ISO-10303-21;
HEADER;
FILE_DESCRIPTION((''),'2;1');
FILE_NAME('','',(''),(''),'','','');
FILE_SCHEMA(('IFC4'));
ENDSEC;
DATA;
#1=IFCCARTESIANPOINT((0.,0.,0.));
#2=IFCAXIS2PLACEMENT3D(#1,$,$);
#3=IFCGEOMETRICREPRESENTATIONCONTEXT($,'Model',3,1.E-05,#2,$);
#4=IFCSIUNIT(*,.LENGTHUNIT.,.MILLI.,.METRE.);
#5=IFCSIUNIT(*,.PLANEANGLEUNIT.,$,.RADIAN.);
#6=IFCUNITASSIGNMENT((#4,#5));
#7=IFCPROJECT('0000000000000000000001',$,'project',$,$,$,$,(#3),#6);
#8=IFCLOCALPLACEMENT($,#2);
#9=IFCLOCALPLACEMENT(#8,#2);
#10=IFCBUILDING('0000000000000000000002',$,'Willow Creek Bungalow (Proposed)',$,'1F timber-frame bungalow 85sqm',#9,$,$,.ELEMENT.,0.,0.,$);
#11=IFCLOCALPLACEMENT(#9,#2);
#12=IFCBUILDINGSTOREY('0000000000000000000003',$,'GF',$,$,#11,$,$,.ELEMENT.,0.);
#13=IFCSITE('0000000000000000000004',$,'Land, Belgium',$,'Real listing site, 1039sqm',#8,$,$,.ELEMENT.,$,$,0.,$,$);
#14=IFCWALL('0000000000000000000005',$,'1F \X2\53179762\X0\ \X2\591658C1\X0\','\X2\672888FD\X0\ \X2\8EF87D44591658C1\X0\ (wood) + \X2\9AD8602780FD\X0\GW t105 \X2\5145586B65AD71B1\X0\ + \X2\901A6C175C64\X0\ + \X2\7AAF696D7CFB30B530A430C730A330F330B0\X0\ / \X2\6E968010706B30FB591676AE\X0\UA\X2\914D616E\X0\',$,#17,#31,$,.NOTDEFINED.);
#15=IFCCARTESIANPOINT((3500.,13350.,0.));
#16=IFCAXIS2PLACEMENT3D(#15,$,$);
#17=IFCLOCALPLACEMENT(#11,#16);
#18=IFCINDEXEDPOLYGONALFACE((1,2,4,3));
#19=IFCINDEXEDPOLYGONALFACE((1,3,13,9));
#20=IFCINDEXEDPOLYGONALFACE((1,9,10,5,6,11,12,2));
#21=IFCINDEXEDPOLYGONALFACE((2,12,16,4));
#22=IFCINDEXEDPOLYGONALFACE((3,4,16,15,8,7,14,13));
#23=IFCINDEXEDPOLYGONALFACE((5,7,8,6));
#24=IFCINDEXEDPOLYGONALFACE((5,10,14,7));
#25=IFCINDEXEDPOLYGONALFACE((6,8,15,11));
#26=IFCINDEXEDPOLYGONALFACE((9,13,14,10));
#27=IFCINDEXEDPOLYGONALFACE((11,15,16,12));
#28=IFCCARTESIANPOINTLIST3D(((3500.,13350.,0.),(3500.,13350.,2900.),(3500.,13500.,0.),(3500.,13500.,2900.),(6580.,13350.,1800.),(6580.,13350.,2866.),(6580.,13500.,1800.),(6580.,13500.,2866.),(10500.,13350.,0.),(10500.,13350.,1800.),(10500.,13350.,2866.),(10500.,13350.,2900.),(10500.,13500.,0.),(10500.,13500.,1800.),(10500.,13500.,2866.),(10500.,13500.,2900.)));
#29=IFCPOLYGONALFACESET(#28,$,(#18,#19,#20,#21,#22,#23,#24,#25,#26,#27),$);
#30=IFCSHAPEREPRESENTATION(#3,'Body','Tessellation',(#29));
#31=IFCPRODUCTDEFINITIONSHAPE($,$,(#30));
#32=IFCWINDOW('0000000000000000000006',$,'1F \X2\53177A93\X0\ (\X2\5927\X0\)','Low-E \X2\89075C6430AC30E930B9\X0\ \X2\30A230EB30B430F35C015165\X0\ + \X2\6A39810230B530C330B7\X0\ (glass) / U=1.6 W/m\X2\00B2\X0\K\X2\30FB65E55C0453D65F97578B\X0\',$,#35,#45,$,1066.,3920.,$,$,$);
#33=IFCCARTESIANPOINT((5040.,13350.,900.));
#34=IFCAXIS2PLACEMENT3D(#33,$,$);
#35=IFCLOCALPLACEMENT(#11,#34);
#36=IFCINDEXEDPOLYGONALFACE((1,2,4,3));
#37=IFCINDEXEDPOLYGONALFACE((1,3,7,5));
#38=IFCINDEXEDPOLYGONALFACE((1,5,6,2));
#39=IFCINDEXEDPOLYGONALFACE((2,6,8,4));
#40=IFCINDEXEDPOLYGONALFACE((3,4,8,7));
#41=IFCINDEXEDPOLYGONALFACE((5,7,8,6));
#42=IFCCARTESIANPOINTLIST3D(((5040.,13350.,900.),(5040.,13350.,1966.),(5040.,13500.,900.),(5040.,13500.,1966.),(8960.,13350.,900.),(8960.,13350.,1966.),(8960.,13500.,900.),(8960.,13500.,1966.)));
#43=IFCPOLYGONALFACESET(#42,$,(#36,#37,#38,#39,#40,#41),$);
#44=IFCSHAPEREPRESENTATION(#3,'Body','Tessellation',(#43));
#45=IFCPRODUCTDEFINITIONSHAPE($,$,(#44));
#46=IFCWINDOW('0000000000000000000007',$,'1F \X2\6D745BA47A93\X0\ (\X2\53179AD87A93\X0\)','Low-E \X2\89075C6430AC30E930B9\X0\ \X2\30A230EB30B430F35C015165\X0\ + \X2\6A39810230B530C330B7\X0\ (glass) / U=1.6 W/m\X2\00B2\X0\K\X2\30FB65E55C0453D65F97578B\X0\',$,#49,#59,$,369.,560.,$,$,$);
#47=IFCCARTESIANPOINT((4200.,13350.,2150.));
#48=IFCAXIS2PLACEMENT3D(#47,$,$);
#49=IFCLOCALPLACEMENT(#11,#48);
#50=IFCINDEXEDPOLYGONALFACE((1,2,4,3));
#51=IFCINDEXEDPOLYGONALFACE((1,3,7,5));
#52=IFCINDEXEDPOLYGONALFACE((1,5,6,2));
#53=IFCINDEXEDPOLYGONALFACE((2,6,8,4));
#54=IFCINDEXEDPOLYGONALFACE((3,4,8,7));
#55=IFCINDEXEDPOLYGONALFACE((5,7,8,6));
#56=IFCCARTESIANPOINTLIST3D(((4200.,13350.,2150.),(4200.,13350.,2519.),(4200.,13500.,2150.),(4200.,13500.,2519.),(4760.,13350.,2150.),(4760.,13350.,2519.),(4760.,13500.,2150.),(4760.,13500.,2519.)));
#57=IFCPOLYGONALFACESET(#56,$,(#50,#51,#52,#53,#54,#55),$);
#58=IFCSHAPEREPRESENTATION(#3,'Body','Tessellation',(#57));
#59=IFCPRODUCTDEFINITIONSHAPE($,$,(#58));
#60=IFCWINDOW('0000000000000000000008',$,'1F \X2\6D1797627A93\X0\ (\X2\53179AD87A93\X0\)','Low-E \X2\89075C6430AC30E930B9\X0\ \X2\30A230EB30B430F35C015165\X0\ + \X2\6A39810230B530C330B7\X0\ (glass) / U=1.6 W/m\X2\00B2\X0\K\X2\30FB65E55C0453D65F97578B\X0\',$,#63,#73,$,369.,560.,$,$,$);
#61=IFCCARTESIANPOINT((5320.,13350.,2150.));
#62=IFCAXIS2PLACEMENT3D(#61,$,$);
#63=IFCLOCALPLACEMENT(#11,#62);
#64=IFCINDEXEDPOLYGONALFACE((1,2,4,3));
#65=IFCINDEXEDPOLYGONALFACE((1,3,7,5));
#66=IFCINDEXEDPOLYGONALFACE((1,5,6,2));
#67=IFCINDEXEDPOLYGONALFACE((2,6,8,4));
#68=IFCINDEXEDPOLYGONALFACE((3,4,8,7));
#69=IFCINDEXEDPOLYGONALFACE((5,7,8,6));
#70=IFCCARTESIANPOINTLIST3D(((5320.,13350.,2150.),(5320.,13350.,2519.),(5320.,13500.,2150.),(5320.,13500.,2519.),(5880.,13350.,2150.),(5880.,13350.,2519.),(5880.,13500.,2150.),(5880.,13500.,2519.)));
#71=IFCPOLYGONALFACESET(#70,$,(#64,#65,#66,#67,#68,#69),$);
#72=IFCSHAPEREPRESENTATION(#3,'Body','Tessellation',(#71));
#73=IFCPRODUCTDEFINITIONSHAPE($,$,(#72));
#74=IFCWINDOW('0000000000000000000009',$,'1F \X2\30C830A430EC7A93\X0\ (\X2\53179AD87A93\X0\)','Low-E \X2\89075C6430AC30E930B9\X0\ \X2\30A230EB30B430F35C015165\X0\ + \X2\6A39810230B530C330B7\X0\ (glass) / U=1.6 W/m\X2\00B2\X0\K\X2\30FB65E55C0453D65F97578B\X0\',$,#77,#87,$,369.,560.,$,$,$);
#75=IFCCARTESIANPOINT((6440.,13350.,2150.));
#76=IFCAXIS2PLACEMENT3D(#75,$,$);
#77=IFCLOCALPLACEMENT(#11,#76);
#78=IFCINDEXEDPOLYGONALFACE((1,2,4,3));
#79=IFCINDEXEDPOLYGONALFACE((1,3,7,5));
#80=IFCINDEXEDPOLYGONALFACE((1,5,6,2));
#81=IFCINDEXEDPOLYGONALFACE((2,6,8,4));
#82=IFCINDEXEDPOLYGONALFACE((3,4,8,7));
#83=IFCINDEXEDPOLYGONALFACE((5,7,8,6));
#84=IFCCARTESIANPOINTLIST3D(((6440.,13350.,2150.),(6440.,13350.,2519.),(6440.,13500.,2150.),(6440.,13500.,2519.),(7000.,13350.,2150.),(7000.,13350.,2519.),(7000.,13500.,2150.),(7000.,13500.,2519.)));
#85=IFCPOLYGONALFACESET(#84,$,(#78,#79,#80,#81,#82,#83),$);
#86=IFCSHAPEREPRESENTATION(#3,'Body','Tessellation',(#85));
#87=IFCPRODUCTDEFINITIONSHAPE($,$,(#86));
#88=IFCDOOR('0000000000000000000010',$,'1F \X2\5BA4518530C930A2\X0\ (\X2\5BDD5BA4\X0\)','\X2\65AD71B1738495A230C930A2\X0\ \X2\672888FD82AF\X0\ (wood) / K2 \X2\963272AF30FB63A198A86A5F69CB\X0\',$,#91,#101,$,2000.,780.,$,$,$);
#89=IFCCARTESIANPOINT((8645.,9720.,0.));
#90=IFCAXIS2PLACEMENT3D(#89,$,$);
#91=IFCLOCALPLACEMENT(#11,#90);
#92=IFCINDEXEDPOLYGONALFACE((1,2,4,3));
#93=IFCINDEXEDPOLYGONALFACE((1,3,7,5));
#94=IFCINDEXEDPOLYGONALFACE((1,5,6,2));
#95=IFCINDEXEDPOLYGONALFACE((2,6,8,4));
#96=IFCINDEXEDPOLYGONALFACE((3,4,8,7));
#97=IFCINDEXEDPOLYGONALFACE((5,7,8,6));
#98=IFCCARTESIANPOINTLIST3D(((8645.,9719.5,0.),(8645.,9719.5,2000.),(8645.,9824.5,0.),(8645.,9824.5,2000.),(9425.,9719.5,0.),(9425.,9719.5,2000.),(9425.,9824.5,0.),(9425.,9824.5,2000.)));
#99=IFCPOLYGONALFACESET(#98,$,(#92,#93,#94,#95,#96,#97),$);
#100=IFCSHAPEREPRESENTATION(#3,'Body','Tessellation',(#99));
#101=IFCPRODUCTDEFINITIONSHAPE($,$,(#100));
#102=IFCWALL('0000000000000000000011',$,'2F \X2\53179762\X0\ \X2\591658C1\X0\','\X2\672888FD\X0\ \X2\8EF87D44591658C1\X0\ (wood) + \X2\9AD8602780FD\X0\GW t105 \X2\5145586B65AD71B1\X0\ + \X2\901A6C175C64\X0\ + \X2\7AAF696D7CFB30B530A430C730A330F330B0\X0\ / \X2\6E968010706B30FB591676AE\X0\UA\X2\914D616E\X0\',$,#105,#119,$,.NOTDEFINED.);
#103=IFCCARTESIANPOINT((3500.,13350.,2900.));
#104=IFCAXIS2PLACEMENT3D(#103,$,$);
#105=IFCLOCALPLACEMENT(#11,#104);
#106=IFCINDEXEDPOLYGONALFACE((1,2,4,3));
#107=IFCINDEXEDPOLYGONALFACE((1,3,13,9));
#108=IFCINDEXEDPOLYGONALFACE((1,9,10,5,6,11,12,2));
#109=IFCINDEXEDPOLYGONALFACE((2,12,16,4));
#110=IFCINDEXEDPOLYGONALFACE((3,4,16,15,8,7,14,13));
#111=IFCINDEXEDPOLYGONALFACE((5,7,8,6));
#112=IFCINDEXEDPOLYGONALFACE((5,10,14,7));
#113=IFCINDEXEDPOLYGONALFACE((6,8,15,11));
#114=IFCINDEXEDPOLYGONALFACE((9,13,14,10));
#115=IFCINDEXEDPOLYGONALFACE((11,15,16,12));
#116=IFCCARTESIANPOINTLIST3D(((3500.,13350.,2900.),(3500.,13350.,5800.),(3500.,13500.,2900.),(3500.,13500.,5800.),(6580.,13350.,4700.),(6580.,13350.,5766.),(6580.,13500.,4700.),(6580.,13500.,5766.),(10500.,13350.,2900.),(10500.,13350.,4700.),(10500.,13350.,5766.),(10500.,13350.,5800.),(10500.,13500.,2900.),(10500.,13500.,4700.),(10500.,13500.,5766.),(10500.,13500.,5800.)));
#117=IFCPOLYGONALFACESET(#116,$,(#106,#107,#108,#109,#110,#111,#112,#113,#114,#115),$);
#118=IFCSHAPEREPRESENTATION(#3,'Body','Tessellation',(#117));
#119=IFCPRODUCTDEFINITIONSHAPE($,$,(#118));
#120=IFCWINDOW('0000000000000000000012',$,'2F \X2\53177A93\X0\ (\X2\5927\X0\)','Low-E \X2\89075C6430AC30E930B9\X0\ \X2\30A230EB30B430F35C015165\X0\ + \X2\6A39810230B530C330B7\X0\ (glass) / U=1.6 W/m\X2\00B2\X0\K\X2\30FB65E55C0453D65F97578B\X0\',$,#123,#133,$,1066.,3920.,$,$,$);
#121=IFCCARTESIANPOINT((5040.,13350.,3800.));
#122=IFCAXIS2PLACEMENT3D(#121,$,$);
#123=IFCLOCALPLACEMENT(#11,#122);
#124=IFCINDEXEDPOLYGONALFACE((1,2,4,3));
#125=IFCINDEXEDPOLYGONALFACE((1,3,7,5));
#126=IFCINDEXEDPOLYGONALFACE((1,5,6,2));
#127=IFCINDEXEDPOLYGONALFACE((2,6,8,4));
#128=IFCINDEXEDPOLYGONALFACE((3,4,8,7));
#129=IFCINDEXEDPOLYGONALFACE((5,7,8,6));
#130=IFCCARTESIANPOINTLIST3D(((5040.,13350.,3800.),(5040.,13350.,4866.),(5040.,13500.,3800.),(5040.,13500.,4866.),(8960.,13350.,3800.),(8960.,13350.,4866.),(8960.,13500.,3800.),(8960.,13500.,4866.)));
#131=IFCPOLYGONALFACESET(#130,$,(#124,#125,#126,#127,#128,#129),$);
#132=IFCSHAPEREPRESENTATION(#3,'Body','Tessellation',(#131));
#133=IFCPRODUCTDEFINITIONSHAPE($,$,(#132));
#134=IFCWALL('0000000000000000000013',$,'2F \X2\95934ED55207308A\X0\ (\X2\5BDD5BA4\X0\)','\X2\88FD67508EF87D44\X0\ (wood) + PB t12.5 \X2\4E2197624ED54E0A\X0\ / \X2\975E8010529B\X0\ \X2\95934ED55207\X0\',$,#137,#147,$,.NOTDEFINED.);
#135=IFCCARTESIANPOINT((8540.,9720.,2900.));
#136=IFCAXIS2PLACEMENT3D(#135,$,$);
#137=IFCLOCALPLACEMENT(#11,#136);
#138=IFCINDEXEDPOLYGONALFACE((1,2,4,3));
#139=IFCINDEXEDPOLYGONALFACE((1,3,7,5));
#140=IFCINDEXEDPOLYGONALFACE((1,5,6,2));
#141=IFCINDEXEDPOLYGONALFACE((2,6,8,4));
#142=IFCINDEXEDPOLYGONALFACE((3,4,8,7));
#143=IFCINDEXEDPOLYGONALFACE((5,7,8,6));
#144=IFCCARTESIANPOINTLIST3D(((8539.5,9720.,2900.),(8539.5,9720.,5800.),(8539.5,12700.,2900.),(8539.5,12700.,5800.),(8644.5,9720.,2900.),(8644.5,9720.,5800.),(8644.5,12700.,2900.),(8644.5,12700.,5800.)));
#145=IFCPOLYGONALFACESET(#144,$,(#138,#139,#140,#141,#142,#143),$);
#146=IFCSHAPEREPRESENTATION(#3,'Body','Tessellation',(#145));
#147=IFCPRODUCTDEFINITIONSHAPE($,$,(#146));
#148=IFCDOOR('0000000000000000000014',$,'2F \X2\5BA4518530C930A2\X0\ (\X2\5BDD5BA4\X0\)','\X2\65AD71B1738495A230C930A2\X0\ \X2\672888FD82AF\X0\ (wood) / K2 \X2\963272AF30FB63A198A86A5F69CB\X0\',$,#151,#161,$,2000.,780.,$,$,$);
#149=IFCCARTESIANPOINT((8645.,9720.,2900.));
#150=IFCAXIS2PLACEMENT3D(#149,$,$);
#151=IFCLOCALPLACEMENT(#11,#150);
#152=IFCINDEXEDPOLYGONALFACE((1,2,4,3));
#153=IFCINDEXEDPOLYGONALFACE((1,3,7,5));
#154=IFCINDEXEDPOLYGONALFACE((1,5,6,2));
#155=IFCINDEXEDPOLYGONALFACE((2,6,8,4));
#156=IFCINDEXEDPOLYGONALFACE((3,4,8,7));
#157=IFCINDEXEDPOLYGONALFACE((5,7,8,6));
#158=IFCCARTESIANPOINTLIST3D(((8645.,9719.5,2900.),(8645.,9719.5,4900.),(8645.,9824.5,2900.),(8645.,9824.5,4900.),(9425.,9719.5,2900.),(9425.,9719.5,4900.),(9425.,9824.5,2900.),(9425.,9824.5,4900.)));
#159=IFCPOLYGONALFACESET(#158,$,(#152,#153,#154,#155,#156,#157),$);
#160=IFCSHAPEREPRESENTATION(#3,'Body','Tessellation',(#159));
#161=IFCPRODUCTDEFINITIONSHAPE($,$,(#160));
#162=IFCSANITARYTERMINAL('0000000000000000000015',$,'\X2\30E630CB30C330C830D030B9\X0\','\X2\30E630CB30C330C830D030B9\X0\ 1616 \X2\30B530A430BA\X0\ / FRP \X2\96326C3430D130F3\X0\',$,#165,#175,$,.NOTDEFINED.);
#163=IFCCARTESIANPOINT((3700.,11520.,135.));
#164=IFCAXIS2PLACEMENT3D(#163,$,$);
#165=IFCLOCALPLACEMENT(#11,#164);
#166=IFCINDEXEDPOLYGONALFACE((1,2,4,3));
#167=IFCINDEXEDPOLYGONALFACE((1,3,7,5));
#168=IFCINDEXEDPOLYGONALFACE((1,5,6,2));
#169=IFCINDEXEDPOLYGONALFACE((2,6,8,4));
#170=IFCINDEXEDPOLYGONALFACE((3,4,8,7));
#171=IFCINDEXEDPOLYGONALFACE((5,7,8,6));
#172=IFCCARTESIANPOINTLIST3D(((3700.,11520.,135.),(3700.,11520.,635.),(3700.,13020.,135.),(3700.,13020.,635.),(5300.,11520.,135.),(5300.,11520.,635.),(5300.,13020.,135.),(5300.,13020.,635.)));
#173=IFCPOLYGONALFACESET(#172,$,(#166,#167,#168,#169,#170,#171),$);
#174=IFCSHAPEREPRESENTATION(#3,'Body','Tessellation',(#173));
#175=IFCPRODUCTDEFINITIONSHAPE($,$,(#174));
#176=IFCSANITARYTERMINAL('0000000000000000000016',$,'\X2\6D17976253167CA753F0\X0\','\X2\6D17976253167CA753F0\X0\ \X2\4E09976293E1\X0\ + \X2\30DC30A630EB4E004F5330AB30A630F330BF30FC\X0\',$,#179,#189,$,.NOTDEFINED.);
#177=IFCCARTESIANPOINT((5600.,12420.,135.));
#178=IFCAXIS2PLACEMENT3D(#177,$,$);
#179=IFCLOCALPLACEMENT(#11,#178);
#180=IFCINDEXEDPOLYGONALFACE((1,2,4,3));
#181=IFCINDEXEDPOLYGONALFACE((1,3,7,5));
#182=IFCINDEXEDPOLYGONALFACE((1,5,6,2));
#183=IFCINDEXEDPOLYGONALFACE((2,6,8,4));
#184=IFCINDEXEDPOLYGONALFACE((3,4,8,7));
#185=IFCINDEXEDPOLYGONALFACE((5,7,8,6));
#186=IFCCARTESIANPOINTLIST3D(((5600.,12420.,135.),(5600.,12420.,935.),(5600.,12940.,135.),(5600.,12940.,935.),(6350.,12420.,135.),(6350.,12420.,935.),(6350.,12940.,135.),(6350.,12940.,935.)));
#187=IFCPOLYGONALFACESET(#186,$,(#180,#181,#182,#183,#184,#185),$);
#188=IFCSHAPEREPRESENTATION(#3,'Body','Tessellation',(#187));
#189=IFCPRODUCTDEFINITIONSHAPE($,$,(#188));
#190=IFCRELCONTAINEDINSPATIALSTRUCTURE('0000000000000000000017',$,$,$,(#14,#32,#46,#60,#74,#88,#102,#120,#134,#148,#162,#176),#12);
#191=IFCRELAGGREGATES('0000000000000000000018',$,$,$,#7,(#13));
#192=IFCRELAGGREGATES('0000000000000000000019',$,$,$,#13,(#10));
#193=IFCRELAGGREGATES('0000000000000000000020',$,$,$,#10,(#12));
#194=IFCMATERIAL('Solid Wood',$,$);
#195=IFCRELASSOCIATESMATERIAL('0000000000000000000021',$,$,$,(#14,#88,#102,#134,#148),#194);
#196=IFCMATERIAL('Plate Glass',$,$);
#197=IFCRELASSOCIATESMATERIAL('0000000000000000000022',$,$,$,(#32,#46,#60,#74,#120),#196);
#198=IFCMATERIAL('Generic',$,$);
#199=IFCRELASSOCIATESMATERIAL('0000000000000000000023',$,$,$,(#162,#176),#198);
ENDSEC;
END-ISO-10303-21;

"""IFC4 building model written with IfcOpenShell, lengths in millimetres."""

from ifc_helpers import new_model, si_unit, frame, frame_2d, origin, place, context, project, spatial, rectangle, extrude, material, element, fill, save


model = new_model("IFC4")

# Units and contexts
model_context = context("Model", 3, precision=1e-05, world=origin())
ifc_project = project(units=[si_unit("LENGTHUNIT", "METRE", prefix="MILLI"), si_unit("PLANEANGLEUNIT", "RADIAN")], contexts=[model_context])

# Site, building, storey
site_placement = place(None, origin())
site = spatial("IfcSite", under=ifc_project, at=site_placement, Name="Land, Belgium", ObjectType="Real listing site, 1039sqm", CompositionType="ELEMENT", RefElevation=0.0)
building_placement = place(site_placement, origin())
building = spatial("IfcBuilding", under=site, at=building_placement, Name="Willow Creek Bungalow (Proposed)", ObjectType="1F timber-frame bungalow 85sqm", CompositionType="ELEMENT", ElevationOfRefHeight=0.0, ElevationOfTerrain=0.0)
storey_placement = place(building_placement, origin())
storey = spatial("IfcBuildingStorey", under=building, at=storey_placement, Name="GF", CompositionType="ELEMENT", Elevation=0.0)

# Wall, openings, windows
ifc_material_1 = material(Name="Solid Wood")
wall_1_placement = place(storey_placement, frame((3500.0, 13350.0, 0.0)))
wall_1 = element("IfcWall", 1, at=wall_1_placement, inside=storey, material=ifc_material_1, Name="1F 北面 外壁", Description="木製 軸組外壁 (wood) + 高性能GW t105 充填断熱 + 通気層 + 窯業系サイディング / 準耐火・外皮UA配慮", PredefinedType="NOTDEFINED", context=model_context, shape_type="SweptSolid", body=[
    extrude(rectangle(XDim=7000.0, YDim=150.0, at=frame_2d((3500.0, 75.0))), frame((3500.0, 13350.0, 0.0)), (0.0, 0.0, 1.0), 2900.0),
])
opening_1_placement = place(storey_placement, frame((5040.0, 13350.0, 900.0)))
opening_1 = element("IfcOpeningElement", 2, at=opening_1_placement, cuts=wall_1, PredefinedType="NOTDEFINED", context=model_context, shape_type="SweptSolid", body=[
    extrude(rectangle(XDim=3920.0, YDim=150.0, at=frame_2d((1960.0, 75.0))), frame((5040.0, 13350.0, 900.0)), (0.0, 0.0, 1.0), 1066.0),
])
opening_2_placement = place(storey_placement, frame((4200.0, 13350.0, 2150.0)))
opening_2 = element("IfcOpeningElement", 3, at=opening_2_placement, cuts=wall_1, PredefinedType="NOTDEFINED", context=model_context, shape_type="SweptSolid", body=[
    extrude(rectangle(XDim=560.0, YDim=150.0, at=frame_2d((280.0, 75.0))), frame((4200.0, 13350.0, 2150.0)), (0.0, 0.0, 1.0), 369.0),
])
opening_3_placement = place(storey_placement, frame((5320.0, 13350.0, 2150.0)))
opening_3 = element("IfcOpeningElement", 4, at=opening_3_placement, cuts=wall_1, PredefinedType="NOTDEFINED", context=model_context, shape_type="SweptSolid", body=[
    extrude(rectangle(XDim=560.0, YDim=150.0, at=frame_2d((280.0, 75.0))), frame((5320.0, 13350.0, 2150.0)), (0.0, 0.0, 1.0), 369.0),
])
opening_4_placement = place(storey_placement, frame((6440.0, 13350.0, 2150.0)))
opening_4 = element("IfcOpeningElement", 5, at=opening_4_placement, cuts=wall_1, PredefinedType="NOTDEFINED", context=model_context, shape_type="SweptSolid", body=[
    extrude(rectangle(XDim=560.0, YDim=150.0, at=frame_2d((280.0, 75.0))), frame((6440.0, 13350.0, 2150.0)), (0.0, 0.0, 1.0), 369.0),
])
ifc_material_2 = material(Name="Plate Glass")
window_1_placement = place(storey_placement, frame((5040.0, 13350.0, 900.0)))
window_1 = element("IfcWindow", 6, at=window_1_placement, inside=storey, material=ifc_material_2, Name="1F 北窓 (大)", Description="Low-E 複層ガラス アルゴン封入 + 樹脂サッシ (glass) / U=1.6 W/m²K・日射取得型", OverallHeight=1066.0, OverallWidth=3920.0, context=model_context, shape_type="SweptSolid", body=[
    extrude(rectangle(XDim=3920.0, YDim=150.0, at=frame_2d((1960.0, 75.0))), frame((5040.0, 13350.0, 900.0)), (0.0, 0.0, 1.0), 1066.0),
])
fill(opening_1, window_1)
window_2_placement = place(storey_placement, frame((4200.0, 13350.0, 2150.0)))
window_2 = element("IfcWindow", 7, at=window_2_placement, inside=storey, material=ifc_material_2, Name="1F 浴室窓 (北高窓)", Description="Low-E 複層ガラス アルゴン封入 + 樹脂サッシ (glass) / U=1.6 W/m²K・日射取得型", OverallHeight=369.0, OverallWidth=560.0, context=model_context, shape_type="SweptSolid", body=[
    extrude(rectangle(XDim=560.0, YDim=150.0, at=frame_2d((280.0, 75.0))), frame((4200.0, 13350.0, 2150.0)), (0.0, 0.0, 1.0), 369.0),
])
fill(opening_2, window_2)
window_3_placement = place(storey_placement, frame((5320.0, 13350.0, 2150.0)))
window_3 = element("IfcWindow", 8, at=window_3_placement, inside=storey, material=ifc_material_2, Name="1F 洗面窓 (北高窓)", Description="Low-E 複層ガラス アルゴン封入 + 樹脂サッシ (glass) / U=1.6 W/m²K・日射取得型", OverallHeight=369.0, OverallWidth=560.0, context=model_context, shape_type="SweptSolid", body=[
    extrude(rectangle(XDim=560.0, YDim=150.0, at=frame_2d((280.0, 75.0))), frame((5320.0, 13350.0, 2150.0)), (0.0, 0.0, 1.0), 369.0),
])
fill(opening_3, window_3)
window_4_placement = place(storey_placement, frame((6440.0, 13350.0, 2150.0)))
window_4 = element("IfcWindow", 9, at=window_4_placement, inside=storey, material=ifc_material_2, Name="1F トイレ窓 (北高窓)", Description="Low-E 複層ガラス アルゴン封入 + 樹脂サッシ (glass) / U=1.6 W/m²K・日射取得型", OverallHeight=369.0, OverallWidth=560.0, context=model_context, shape_type="SweptSolid", body=[
    extrude(rectangle(XDim=560.0, YDim=150.0, at=frame_2d((280.0, 75.0))), frame((6440.0, 13350.0, 2150.0)), (0.0, 0.0, 1.0), 369.0),
])
fill(opening_4, window_4)

# Door
door_1_placement = place(storey_placement, frame((8645.0, 9720.0, 0.0)))
element("IfcDoor", 10, at=door_1_placement, inside=storey, material=ifc_material_1, Name="1F 室内ドア (寝室)", Description="断熱玄関ドア 木製芯 (wood) / K2 防犯・採風機構", OverallHeight=2000.0, OverallWidth=780.0, context=model_context, shape_type="SweptSolid", body=[
    extrude(rectangle(XDim=780.0, YDim=105.0, at=frame_2d((390.0, 52.0))), frame((8645.0, 9720.0, 0.0)), (0.0, 0.0, 1.0), 2000.0),
])

# Wall, opening, window
wall_2_placement = place(storey_placement, frame((3500.0, 13350.0, 2900.0)))
wall_2 = element("IfcWall", 11, at=wall_2_placement, inside=storey, material=ifc_material_1, Name="2F 北面 外壁", Description="木製 軸組外壁 (wood) + 高性能GW t105 充填断熱 + 通気層 + 窯業系サイディング / 準耐火・外皮UA配慮", PredefinedType="NOTDEFINED", context=model_context, shape_type="SweptSolid", body=[
    extrude(rectangle(XDim=7000.0, YDim=150.0, at=frame_2d((3500.0, 75.0))), frame((3500.0, 13350.0, 2900.0)), (0.0, 0.0, 1.0), 2900.0),
])
opening_5_placement = place(storey_placement, frame((5040.0, 13350.0, 3800.0)))
opening_5 = element("IfcOpeningElement", 12, at=opening_5_placement, cuts=wall_2, PredefinedType="NOTDEFINED", context=model_context, shape_type="SweptSolid", body=[
    extrude(rectangle(XDim=3920.0, YDim=150.0, at=frame_2d((1960.0, 75.0))), frame((5040.0, 13350.0, 3800.0)), (0.0, 0.0, 1.0), 1066.0),
])
window_5_placement = place(storey_placement, frame((5040.0, 13350.0, 3800.0)))
window_5 = element("IfcWindow", 13, at=window_5_placement, inside=storey, material=ifc_material_2, Name="2F 北窓 (大)", Description="Low-E 複層ガラス アルゴン封入 + 樹脂サッシ (glass) / U=1.6 W/m²K・日射取得型", OverallHeight=1066.0, OverallWidth=3920.0, context=model_context, shape_type="SweptSolid", body=[
    extrude(rectangle(XDim=3920.0, YDim=150.0, at=frame_2d((1960.0, 75.0))), frame((5040.0, 13350.0, 3800.0)), (0.0, 0.0, 1.0), 1066.0),
])
fill(opening_5, window_5)

# Wall
wall_3_placement = place(storey_placement, frame((8540.0, 9720.0, 2900.0)))
element("IfcWall", 14, at=wall_3_placement, inside=storey, material=ifc_material_1, Name="2F 間仕切り (寝室)", Description="製材軸組 (wood) + PB t12.5 両面仕上 / 非耐力 間仕切", PredefinedType="NOTDEFINED", context=model_context, shape_type="SweptSolid", body=[
    extrude(rectangle(XDim=105.0, YDim=2980.0, at=frame_2d((52.0, 1490.0))), frame((8540.0, 9720.0, 2900.0)), (0.0, 0.0, 1.0), 2900.0),
])

# Door
door_2_placement = place(storey_placement, frame((8645.0, 9720.0, 2900.0)))
element("IfcDoor", 15, at=door_2_placement, inside=storey, material=ifc_material_1, Name="2F 室内ドア (寝室)", Description="断熱玄関ドア 木製芯 (wood) / K2 防犯・採風機構", OverallHeight=2000.0, OverallWidth=780.0, context=model_context, shape_type="SweptSolid", body=[
    extrude(rectangle(XDim=780.0, YDim=105.0, at=frame_2d((390.0, 52.0))), frame((8645.0, 9720.0, 2900.0)), (0.0, 0.0, 1.0), 2000.0),
])

# Sanitary terminals
ifc_material_3 = material(Name="Generic")
sanitary_terminal_1_placement = place(storey_placement, frame((3700.0, 11520.0, 135.0)))
element("IfcSanitaryTerminal", 16, at=sanitary_terminal_1_placement, inside=storey, material=ifc_material_3, Name="ユニットバス", Description="ユニットバス 1616 サイズ / FRP 防水パン", PredefinedType="NOTDEFINED", context=model_context, shape_type="SweptSolid", body=[
    extrude(rectangle(XDim=1600.0, YDim=1500.0, at=frame_2d((800.0, 750.0))), frame((3700.0, 11520.0, 135.0)), (0.0, 0.0, 1.0), 500.0),
])
sanitary_terminal_2_placement = place(storey_placement, frame((5600.0, 12420.0, 135.0)))
element("IfcSanitaryTerminal", 17, at=sanitary_terminal_2_placement, inside=storey, material=ifc_material_3, Name="洗面化粧台", Description="洗面化粧台 三面鏡 + ボウル一体カウンター", PredefinedType="NOTDEFINED", context=model_context, shape_type="SweptSolid", body=[
    extrude(rectangle(XDim=750.0, YDim=520.0, at=frame_2d((375.0, 260.0))), frame((5600.0, 12420.0, 135.0)), (0.0, 0.0, 1.0), 800.0),
])

save(model, "model.ifc")
